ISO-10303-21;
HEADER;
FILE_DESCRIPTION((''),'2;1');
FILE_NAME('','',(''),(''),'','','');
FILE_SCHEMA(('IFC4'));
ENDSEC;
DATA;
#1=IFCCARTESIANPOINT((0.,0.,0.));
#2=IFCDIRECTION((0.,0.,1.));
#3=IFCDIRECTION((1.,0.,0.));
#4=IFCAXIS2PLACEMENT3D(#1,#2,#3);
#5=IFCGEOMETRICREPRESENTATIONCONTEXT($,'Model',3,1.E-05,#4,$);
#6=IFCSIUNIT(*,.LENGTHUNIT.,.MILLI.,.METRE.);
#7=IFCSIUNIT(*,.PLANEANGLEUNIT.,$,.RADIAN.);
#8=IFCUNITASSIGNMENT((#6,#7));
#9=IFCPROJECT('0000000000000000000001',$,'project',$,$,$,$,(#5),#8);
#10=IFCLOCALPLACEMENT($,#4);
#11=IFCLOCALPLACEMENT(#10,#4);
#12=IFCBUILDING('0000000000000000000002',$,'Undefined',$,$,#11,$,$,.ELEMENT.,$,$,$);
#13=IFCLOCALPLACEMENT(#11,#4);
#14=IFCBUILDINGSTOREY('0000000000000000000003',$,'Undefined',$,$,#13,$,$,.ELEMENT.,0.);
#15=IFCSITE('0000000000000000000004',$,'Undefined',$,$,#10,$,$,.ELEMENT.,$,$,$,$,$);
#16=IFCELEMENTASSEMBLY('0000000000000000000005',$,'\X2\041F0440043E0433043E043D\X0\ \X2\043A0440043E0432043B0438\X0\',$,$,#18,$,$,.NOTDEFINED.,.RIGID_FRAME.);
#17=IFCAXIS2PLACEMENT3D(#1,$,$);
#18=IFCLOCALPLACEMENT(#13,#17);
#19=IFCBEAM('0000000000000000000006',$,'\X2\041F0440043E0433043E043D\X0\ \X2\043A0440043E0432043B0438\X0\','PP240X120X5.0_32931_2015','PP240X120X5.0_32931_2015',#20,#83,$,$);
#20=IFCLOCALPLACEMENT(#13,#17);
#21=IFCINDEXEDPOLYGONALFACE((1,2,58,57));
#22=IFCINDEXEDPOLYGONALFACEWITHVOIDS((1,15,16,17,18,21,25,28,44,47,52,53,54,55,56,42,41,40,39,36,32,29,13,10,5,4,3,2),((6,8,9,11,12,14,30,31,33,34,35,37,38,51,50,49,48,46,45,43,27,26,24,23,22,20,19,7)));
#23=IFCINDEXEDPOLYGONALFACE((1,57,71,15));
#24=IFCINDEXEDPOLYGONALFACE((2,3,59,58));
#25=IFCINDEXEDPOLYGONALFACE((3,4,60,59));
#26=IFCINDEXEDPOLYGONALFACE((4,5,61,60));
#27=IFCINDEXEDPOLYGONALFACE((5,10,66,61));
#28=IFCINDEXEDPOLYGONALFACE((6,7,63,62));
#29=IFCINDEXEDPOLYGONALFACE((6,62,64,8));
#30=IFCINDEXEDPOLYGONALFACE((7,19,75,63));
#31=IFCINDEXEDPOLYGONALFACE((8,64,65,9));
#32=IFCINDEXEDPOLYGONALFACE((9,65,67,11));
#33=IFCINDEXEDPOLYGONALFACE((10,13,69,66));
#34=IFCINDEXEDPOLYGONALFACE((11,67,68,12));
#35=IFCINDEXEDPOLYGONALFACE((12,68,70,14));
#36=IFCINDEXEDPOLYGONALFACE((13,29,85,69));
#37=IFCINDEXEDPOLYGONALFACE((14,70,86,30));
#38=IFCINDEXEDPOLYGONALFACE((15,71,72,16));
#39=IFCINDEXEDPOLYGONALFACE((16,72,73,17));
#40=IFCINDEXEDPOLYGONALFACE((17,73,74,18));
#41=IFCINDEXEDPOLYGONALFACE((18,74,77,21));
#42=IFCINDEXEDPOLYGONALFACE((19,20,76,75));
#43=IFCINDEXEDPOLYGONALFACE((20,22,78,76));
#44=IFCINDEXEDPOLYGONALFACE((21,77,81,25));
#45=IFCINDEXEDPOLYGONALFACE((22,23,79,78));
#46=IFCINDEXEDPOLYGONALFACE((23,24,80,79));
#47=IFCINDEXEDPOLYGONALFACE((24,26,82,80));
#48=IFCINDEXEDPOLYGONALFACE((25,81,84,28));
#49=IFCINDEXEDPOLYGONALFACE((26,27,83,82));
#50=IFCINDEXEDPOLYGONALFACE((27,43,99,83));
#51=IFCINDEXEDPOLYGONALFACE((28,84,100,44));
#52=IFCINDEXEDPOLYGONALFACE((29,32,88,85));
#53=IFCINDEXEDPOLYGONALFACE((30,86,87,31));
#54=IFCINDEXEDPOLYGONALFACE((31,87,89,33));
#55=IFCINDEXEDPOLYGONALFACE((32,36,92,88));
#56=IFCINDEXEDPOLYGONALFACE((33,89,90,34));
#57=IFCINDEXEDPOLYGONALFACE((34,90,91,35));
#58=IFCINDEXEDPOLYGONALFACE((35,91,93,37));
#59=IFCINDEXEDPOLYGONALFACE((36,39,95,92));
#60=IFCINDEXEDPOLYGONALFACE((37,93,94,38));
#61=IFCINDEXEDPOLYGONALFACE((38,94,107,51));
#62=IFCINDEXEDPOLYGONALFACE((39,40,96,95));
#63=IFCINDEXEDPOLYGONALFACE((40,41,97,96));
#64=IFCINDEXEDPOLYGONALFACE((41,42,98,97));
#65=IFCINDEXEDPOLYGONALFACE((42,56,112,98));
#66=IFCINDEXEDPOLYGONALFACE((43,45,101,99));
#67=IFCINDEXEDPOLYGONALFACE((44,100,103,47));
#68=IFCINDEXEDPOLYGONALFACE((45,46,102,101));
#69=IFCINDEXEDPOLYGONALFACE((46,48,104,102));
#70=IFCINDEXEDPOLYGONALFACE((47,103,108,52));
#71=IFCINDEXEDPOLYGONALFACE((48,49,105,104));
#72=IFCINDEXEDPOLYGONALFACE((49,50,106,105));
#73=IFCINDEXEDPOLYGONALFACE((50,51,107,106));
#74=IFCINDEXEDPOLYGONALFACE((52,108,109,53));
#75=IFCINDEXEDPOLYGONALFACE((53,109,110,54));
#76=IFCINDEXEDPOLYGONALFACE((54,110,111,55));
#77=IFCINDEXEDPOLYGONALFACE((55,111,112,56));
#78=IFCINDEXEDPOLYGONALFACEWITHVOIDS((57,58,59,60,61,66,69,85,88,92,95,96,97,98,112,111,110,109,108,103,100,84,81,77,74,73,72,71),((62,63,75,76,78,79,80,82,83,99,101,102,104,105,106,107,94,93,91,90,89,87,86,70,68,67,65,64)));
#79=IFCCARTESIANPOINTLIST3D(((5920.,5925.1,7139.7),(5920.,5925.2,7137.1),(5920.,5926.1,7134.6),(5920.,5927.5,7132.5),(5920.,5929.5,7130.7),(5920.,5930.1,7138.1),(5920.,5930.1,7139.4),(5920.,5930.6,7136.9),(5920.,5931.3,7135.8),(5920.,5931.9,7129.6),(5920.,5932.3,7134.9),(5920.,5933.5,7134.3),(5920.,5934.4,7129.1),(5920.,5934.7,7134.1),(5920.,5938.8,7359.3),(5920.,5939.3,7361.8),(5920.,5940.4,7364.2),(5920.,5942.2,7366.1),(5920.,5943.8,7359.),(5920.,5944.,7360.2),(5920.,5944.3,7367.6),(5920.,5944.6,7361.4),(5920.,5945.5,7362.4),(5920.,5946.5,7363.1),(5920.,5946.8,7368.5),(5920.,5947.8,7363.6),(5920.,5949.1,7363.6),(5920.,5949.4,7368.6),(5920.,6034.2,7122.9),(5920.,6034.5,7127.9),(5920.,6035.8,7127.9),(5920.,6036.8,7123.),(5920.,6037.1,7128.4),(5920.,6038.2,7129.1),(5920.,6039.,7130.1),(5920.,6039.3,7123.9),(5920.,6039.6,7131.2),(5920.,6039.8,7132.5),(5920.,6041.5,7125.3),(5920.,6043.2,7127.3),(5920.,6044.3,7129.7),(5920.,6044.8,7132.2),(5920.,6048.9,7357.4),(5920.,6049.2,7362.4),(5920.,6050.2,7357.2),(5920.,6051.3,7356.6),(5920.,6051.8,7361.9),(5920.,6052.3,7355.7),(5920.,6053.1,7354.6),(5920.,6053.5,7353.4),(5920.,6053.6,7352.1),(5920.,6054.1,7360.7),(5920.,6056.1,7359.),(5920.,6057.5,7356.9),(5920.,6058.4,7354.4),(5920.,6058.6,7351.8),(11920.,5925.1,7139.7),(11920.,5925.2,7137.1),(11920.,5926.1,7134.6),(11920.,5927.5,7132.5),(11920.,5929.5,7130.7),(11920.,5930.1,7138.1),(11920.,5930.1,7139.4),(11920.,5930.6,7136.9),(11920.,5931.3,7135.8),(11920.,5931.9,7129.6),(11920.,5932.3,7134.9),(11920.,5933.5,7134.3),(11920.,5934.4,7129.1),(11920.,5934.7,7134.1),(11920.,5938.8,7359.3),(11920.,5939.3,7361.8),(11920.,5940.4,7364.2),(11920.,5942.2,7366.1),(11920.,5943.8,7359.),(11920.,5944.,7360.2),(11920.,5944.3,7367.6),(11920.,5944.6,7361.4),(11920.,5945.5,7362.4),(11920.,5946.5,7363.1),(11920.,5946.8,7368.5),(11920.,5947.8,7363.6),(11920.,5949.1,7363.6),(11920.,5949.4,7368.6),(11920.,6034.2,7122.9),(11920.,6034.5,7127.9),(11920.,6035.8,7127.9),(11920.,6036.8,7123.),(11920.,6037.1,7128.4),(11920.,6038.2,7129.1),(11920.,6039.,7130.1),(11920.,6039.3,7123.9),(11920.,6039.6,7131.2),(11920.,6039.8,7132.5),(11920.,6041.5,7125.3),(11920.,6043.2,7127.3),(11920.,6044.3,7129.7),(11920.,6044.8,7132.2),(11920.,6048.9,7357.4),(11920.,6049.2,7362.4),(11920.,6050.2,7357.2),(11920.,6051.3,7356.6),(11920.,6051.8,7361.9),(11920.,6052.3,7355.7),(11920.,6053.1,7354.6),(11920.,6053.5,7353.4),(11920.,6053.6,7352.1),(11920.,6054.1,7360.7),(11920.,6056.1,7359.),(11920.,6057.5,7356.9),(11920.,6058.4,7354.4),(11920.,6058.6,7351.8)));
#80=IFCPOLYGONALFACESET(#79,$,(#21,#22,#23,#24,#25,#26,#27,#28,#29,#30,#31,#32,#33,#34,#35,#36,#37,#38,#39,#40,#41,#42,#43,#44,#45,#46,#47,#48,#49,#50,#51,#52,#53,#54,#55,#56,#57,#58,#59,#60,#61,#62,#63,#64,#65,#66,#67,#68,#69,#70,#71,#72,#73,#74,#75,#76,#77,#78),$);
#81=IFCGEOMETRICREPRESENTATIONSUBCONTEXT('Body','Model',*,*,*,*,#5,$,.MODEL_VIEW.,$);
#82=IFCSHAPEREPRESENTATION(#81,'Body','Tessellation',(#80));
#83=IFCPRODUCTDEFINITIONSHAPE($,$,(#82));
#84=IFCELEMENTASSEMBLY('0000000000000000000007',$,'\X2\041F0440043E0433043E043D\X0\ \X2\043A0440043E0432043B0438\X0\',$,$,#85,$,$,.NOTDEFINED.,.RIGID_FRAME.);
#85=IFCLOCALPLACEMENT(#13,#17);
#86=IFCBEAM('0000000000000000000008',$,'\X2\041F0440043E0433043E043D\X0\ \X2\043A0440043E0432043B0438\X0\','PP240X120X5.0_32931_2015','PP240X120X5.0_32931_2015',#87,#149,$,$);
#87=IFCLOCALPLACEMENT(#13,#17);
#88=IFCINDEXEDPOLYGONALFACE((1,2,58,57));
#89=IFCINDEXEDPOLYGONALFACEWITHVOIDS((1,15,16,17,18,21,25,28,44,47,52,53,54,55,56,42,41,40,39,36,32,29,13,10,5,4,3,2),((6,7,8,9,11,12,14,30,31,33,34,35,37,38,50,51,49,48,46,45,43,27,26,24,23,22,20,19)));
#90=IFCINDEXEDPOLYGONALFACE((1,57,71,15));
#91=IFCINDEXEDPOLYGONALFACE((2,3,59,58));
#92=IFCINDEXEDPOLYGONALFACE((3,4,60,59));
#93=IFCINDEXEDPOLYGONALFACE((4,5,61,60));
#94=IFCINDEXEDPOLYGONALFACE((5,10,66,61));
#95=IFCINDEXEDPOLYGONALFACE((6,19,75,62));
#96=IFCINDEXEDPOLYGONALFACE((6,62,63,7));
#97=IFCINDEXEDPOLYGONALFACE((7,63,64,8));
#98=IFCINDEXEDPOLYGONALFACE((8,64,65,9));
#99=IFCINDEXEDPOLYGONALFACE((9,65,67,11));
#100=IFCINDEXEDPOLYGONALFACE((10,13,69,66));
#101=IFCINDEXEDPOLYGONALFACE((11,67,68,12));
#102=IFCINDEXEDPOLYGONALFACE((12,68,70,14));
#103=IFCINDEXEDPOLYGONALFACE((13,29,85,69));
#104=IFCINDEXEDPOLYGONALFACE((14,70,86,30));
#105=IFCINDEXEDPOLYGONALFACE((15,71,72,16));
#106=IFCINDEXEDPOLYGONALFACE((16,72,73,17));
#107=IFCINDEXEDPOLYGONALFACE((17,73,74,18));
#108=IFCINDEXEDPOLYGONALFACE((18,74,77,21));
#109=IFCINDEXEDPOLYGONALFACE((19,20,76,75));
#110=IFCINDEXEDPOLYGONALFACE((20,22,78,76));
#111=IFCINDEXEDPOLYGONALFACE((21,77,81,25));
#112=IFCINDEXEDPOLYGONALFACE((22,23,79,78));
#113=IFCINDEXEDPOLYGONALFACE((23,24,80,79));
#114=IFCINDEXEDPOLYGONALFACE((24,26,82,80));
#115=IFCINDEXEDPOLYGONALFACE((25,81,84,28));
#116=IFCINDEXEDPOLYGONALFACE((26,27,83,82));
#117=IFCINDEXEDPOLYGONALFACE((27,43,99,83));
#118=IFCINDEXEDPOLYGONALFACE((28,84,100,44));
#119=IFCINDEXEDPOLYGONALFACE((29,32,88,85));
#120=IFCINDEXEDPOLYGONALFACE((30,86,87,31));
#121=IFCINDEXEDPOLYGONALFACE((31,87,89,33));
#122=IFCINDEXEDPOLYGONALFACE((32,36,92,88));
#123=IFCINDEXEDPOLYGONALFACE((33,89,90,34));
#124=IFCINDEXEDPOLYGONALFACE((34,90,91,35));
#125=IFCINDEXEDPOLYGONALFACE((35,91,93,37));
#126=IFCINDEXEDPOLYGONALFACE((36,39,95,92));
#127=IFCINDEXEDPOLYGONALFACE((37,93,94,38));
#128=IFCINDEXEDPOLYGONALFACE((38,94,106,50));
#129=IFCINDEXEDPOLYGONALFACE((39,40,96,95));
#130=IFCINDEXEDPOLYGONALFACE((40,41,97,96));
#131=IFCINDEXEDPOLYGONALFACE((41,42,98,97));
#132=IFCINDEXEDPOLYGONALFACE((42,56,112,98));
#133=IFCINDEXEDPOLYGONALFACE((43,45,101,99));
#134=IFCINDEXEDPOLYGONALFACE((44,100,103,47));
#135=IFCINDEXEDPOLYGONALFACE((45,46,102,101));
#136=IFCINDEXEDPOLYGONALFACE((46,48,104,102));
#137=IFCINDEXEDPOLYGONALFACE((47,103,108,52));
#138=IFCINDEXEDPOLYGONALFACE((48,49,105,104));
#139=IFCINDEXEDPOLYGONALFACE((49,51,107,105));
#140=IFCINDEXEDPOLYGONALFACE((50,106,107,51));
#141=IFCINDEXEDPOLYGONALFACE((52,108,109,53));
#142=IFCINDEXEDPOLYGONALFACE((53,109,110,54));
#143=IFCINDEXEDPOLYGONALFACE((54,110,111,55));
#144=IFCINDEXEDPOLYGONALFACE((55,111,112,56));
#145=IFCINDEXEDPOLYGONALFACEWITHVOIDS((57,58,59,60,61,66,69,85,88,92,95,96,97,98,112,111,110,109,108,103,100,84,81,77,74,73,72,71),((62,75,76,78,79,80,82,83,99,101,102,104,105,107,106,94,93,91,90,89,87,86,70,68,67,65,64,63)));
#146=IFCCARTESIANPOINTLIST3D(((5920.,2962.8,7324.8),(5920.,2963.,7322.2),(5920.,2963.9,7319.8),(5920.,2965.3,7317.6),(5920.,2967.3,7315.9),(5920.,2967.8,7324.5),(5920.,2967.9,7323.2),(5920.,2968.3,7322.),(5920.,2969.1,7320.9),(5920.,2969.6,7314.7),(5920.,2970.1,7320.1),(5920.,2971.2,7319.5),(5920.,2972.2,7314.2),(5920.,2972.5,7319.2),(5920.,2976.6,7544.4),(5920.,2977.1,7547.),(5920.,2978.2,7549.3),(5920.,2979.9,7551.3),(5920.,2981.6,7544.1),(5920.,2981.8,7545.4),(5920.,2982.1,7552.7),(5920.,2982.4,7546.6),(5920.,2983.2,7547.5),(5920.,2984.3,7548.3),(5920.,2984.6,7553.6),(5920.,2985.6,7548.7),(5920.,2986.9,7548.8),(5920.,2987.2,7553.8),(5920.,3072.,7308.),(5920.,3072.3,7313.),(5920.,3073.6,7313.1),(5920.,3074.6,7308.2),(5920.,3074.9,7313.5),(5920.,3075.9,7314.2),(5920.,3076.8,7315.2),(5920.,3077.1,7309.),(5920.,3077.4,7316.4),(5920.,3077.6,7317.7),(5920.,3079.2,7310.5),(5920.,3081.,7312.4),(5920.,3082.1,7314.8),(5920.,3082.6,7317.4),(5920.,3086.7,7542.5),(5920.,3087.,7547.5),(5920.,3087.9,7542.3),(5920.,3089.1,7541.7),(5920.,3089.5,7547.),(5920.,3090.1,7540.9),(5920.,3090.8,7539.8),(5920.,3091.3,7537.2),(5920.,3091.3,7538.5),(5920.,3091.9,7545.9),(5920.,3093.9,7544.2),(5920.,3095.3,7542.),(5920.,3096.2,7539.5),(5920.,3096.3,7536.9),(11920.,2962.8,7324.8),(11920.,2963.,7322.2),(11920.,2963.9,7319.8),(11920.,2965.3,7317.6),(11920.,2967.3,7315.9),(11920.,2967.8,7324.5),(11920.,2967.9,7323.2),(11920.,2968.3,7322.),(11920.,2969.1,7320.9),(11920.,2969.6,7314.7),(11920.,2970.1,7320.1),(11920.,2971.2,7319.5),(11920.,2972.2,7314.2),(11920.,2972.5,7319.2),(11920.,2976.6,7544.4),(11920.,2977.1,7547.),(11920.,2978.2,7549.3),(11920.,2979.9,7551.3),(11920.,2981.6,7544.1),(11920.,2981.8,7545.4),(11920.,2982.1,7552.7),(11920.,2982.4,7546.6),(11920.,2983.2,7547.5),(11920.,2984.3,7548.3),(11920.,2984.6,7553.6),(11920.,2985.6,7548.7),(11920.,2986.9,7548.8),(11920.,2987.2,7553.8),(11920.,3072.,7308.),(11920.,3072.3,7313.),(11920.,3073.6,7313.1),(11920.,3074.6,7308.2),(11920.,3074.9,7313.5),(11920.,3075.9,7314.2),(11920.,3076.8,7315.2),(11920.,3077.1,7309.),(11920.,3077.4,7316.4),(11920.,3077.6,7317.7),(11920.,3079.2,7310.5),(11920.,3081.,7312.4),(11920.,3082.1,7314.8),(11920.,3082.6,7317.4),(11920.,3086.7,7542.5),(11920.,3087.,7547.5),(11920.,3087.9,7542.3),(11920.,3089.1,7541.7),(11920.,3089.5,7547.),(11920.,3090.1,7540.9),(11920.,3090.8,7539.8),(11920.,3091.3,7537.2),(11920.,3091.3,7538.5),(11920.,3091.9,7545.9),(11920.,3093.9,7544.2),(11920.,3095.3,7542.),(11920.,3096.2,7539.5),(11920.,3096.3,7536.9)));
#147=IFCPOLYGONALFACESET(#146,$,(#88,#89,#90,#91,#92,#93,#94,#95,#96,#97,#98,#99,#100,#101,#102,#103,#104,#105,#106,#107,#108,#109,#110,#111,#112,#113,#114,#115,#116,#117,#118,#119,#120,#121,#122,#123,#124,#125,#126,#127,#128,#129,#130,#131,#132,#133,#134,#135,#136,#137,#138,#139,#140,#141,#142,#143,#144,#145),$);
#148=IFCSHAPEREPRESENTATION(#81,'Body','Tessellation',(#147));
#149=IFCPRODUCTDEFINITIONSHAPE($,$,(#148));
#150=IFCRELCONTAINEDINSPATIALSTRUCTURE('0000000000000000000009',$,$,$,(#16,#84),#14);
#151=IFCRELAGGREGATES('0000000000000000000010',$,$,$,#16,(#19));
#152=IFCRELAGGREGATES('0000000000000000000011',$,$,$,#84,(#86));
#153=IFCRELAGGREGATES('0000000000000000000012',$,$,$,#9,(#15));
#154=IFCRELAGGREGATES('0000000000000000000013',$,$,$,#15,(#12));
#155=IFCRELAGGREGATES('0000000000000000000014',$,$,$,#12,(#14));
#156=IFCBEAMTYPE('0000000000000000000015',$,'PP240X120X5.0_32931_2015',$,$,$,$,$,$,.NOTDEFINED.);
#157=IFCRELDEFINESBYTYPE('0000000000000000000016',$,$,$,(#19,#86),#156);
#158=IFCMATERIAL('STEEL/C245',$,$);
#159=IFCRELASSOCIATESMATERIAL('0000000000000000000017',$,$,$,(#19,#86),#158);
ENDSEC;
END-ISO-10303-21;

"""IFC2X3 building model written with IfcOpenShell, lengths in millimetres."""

from ifc_helpers import new_model, si_unit, frame, origin_with_axes, origin_2d_with_axis, place, context, subcontext, project, spatial, hollow_rectangle, extrude, material, type_object, element, aggregate, save


model = new_model("IFC2X3")

# Units and contexts
model_context = context("Model", 3, precision=1e-05, world=origin_with_axes())
body_context = subcontext(model_context, "Body", "Model", "MODEL_VIEW")
ifc_project = project(units=[si_unit("LENGTHUNIT", "METRE", prefix="MILLI"), si_unit("PLANEANGLEUNIT", "RADIAN")], contexts=[model_context])

# Site, building, storey
site_placement = place(None, origin_with_axes())
site = spatial("IfcSite", under=ifc_project, at=site_placement, Name="Undefined", CompositionType="ELEMENT")
building_placement = place(site_placement, origin_with_axes())
building = spatial("IfcBuilding", under=site, at=building_placement, Name="Undefined", CompositionType="ELEMENT")
storey_placement = place(building_placement, origin_with_axes())
storey = spatial("IfcBuildingStorey", under=building, at=storey_placement, Name="Undefined", CompositionType="ELEMENT", Elevation=0.0)

# Shared definitions
ifc_material = material(Name="STEEL/C245")

# Element assemblies, beams
beam_type_1 = type_object("IfcBeamType", Name="PP240X120X5.0_32931_2015", PredefinedType="NOTDEFINED")
assembly_1_placement = place(storey_placement, origin_with_axes())
assembly_1 = element("IfcElementAssembly", 1, at=assembly_1_placement, inside=storey, Name="Прогон кровли", AssemblyPlace="NOTDEFINED", PredefinedType="RIGID_FRAME")
beam_1_placement = place(assembly_1_placement, frame((11920.0, 5991.8, 7245.7), z_axis=(0.0, 0.062378, 0.998053), x_axis=(-1.0, 0.0, 0.0)))
beam_1 = element("IfcBeam", 2, at=beam_1_placement, type_object=beam_type_1, material=ifc_material, Name="Прогон кровли", Description="PP240X120X5.0_32931_2015", ObjectType="PP240X120X5.0_32931_2015", context=body_context, shape_type="SweptSolid", body=[
    extrude(hollow_rectangle(XDim=120.0, YDim=240.0, WallThickness=5.0, InnerFilletRadius=5.0, OuterFilletRadius=10.0, at=origin_2d_with_axis()), frame((6000.0, 0.0, 0.0), z_axis=(-1.0, 0.0, 0.0), x_axis=(0.0, -1.0, 0.0)), (0.0, 0.0, 1.0), 6000.0),
])
aggregate(assembly_1, [beam_1])
assembly_2_placement = place(storey_placement, origin_with_axes())
assembly_2 = element("IfcElementAssembly", 3, at=assembly_2_placement, inside=storey, Name="Прогон кровли", AssemblyPlace="NOTDEFINED", PredefinedType="RIGID_FRAME")
beam_2_placement = place(assembly_2_placement, frame((11920.0, 3029.6, 7430.9), z_axis=(0.0, 0.062378, 0.998053), x_axis=(-1.0, 0.0, 0.0)))
beam_2 = element("IfcBeam", 4, at=beam_2_placement, type_object=beam_type_1, material=ifc_material, Name="Прогон кровли", Description="PP240X120X5.0_32931_2015", ObjectType="PP240X120X5.0_32931_2015", context=body_context, shape_type="SweptSolid", body=[
    extrude(hollow_rectangle(XDim=120.0, YDim=240.0, WallThickness=5.0, InnerFilletRadius=5.0, OuterFilletRadius=10.0, at=origin_2d_with_axis()), frame((6000.0, 0.0, 0.0), z_axis=(-1.0, 0.0, 0.0), x_axis=(0.0, -1.0, 0.0)), (0.0, 0.0, 1.0), 6000.0),
])
aggregate(assembly_2, [beam_2])

save(model, "model.ifc")
